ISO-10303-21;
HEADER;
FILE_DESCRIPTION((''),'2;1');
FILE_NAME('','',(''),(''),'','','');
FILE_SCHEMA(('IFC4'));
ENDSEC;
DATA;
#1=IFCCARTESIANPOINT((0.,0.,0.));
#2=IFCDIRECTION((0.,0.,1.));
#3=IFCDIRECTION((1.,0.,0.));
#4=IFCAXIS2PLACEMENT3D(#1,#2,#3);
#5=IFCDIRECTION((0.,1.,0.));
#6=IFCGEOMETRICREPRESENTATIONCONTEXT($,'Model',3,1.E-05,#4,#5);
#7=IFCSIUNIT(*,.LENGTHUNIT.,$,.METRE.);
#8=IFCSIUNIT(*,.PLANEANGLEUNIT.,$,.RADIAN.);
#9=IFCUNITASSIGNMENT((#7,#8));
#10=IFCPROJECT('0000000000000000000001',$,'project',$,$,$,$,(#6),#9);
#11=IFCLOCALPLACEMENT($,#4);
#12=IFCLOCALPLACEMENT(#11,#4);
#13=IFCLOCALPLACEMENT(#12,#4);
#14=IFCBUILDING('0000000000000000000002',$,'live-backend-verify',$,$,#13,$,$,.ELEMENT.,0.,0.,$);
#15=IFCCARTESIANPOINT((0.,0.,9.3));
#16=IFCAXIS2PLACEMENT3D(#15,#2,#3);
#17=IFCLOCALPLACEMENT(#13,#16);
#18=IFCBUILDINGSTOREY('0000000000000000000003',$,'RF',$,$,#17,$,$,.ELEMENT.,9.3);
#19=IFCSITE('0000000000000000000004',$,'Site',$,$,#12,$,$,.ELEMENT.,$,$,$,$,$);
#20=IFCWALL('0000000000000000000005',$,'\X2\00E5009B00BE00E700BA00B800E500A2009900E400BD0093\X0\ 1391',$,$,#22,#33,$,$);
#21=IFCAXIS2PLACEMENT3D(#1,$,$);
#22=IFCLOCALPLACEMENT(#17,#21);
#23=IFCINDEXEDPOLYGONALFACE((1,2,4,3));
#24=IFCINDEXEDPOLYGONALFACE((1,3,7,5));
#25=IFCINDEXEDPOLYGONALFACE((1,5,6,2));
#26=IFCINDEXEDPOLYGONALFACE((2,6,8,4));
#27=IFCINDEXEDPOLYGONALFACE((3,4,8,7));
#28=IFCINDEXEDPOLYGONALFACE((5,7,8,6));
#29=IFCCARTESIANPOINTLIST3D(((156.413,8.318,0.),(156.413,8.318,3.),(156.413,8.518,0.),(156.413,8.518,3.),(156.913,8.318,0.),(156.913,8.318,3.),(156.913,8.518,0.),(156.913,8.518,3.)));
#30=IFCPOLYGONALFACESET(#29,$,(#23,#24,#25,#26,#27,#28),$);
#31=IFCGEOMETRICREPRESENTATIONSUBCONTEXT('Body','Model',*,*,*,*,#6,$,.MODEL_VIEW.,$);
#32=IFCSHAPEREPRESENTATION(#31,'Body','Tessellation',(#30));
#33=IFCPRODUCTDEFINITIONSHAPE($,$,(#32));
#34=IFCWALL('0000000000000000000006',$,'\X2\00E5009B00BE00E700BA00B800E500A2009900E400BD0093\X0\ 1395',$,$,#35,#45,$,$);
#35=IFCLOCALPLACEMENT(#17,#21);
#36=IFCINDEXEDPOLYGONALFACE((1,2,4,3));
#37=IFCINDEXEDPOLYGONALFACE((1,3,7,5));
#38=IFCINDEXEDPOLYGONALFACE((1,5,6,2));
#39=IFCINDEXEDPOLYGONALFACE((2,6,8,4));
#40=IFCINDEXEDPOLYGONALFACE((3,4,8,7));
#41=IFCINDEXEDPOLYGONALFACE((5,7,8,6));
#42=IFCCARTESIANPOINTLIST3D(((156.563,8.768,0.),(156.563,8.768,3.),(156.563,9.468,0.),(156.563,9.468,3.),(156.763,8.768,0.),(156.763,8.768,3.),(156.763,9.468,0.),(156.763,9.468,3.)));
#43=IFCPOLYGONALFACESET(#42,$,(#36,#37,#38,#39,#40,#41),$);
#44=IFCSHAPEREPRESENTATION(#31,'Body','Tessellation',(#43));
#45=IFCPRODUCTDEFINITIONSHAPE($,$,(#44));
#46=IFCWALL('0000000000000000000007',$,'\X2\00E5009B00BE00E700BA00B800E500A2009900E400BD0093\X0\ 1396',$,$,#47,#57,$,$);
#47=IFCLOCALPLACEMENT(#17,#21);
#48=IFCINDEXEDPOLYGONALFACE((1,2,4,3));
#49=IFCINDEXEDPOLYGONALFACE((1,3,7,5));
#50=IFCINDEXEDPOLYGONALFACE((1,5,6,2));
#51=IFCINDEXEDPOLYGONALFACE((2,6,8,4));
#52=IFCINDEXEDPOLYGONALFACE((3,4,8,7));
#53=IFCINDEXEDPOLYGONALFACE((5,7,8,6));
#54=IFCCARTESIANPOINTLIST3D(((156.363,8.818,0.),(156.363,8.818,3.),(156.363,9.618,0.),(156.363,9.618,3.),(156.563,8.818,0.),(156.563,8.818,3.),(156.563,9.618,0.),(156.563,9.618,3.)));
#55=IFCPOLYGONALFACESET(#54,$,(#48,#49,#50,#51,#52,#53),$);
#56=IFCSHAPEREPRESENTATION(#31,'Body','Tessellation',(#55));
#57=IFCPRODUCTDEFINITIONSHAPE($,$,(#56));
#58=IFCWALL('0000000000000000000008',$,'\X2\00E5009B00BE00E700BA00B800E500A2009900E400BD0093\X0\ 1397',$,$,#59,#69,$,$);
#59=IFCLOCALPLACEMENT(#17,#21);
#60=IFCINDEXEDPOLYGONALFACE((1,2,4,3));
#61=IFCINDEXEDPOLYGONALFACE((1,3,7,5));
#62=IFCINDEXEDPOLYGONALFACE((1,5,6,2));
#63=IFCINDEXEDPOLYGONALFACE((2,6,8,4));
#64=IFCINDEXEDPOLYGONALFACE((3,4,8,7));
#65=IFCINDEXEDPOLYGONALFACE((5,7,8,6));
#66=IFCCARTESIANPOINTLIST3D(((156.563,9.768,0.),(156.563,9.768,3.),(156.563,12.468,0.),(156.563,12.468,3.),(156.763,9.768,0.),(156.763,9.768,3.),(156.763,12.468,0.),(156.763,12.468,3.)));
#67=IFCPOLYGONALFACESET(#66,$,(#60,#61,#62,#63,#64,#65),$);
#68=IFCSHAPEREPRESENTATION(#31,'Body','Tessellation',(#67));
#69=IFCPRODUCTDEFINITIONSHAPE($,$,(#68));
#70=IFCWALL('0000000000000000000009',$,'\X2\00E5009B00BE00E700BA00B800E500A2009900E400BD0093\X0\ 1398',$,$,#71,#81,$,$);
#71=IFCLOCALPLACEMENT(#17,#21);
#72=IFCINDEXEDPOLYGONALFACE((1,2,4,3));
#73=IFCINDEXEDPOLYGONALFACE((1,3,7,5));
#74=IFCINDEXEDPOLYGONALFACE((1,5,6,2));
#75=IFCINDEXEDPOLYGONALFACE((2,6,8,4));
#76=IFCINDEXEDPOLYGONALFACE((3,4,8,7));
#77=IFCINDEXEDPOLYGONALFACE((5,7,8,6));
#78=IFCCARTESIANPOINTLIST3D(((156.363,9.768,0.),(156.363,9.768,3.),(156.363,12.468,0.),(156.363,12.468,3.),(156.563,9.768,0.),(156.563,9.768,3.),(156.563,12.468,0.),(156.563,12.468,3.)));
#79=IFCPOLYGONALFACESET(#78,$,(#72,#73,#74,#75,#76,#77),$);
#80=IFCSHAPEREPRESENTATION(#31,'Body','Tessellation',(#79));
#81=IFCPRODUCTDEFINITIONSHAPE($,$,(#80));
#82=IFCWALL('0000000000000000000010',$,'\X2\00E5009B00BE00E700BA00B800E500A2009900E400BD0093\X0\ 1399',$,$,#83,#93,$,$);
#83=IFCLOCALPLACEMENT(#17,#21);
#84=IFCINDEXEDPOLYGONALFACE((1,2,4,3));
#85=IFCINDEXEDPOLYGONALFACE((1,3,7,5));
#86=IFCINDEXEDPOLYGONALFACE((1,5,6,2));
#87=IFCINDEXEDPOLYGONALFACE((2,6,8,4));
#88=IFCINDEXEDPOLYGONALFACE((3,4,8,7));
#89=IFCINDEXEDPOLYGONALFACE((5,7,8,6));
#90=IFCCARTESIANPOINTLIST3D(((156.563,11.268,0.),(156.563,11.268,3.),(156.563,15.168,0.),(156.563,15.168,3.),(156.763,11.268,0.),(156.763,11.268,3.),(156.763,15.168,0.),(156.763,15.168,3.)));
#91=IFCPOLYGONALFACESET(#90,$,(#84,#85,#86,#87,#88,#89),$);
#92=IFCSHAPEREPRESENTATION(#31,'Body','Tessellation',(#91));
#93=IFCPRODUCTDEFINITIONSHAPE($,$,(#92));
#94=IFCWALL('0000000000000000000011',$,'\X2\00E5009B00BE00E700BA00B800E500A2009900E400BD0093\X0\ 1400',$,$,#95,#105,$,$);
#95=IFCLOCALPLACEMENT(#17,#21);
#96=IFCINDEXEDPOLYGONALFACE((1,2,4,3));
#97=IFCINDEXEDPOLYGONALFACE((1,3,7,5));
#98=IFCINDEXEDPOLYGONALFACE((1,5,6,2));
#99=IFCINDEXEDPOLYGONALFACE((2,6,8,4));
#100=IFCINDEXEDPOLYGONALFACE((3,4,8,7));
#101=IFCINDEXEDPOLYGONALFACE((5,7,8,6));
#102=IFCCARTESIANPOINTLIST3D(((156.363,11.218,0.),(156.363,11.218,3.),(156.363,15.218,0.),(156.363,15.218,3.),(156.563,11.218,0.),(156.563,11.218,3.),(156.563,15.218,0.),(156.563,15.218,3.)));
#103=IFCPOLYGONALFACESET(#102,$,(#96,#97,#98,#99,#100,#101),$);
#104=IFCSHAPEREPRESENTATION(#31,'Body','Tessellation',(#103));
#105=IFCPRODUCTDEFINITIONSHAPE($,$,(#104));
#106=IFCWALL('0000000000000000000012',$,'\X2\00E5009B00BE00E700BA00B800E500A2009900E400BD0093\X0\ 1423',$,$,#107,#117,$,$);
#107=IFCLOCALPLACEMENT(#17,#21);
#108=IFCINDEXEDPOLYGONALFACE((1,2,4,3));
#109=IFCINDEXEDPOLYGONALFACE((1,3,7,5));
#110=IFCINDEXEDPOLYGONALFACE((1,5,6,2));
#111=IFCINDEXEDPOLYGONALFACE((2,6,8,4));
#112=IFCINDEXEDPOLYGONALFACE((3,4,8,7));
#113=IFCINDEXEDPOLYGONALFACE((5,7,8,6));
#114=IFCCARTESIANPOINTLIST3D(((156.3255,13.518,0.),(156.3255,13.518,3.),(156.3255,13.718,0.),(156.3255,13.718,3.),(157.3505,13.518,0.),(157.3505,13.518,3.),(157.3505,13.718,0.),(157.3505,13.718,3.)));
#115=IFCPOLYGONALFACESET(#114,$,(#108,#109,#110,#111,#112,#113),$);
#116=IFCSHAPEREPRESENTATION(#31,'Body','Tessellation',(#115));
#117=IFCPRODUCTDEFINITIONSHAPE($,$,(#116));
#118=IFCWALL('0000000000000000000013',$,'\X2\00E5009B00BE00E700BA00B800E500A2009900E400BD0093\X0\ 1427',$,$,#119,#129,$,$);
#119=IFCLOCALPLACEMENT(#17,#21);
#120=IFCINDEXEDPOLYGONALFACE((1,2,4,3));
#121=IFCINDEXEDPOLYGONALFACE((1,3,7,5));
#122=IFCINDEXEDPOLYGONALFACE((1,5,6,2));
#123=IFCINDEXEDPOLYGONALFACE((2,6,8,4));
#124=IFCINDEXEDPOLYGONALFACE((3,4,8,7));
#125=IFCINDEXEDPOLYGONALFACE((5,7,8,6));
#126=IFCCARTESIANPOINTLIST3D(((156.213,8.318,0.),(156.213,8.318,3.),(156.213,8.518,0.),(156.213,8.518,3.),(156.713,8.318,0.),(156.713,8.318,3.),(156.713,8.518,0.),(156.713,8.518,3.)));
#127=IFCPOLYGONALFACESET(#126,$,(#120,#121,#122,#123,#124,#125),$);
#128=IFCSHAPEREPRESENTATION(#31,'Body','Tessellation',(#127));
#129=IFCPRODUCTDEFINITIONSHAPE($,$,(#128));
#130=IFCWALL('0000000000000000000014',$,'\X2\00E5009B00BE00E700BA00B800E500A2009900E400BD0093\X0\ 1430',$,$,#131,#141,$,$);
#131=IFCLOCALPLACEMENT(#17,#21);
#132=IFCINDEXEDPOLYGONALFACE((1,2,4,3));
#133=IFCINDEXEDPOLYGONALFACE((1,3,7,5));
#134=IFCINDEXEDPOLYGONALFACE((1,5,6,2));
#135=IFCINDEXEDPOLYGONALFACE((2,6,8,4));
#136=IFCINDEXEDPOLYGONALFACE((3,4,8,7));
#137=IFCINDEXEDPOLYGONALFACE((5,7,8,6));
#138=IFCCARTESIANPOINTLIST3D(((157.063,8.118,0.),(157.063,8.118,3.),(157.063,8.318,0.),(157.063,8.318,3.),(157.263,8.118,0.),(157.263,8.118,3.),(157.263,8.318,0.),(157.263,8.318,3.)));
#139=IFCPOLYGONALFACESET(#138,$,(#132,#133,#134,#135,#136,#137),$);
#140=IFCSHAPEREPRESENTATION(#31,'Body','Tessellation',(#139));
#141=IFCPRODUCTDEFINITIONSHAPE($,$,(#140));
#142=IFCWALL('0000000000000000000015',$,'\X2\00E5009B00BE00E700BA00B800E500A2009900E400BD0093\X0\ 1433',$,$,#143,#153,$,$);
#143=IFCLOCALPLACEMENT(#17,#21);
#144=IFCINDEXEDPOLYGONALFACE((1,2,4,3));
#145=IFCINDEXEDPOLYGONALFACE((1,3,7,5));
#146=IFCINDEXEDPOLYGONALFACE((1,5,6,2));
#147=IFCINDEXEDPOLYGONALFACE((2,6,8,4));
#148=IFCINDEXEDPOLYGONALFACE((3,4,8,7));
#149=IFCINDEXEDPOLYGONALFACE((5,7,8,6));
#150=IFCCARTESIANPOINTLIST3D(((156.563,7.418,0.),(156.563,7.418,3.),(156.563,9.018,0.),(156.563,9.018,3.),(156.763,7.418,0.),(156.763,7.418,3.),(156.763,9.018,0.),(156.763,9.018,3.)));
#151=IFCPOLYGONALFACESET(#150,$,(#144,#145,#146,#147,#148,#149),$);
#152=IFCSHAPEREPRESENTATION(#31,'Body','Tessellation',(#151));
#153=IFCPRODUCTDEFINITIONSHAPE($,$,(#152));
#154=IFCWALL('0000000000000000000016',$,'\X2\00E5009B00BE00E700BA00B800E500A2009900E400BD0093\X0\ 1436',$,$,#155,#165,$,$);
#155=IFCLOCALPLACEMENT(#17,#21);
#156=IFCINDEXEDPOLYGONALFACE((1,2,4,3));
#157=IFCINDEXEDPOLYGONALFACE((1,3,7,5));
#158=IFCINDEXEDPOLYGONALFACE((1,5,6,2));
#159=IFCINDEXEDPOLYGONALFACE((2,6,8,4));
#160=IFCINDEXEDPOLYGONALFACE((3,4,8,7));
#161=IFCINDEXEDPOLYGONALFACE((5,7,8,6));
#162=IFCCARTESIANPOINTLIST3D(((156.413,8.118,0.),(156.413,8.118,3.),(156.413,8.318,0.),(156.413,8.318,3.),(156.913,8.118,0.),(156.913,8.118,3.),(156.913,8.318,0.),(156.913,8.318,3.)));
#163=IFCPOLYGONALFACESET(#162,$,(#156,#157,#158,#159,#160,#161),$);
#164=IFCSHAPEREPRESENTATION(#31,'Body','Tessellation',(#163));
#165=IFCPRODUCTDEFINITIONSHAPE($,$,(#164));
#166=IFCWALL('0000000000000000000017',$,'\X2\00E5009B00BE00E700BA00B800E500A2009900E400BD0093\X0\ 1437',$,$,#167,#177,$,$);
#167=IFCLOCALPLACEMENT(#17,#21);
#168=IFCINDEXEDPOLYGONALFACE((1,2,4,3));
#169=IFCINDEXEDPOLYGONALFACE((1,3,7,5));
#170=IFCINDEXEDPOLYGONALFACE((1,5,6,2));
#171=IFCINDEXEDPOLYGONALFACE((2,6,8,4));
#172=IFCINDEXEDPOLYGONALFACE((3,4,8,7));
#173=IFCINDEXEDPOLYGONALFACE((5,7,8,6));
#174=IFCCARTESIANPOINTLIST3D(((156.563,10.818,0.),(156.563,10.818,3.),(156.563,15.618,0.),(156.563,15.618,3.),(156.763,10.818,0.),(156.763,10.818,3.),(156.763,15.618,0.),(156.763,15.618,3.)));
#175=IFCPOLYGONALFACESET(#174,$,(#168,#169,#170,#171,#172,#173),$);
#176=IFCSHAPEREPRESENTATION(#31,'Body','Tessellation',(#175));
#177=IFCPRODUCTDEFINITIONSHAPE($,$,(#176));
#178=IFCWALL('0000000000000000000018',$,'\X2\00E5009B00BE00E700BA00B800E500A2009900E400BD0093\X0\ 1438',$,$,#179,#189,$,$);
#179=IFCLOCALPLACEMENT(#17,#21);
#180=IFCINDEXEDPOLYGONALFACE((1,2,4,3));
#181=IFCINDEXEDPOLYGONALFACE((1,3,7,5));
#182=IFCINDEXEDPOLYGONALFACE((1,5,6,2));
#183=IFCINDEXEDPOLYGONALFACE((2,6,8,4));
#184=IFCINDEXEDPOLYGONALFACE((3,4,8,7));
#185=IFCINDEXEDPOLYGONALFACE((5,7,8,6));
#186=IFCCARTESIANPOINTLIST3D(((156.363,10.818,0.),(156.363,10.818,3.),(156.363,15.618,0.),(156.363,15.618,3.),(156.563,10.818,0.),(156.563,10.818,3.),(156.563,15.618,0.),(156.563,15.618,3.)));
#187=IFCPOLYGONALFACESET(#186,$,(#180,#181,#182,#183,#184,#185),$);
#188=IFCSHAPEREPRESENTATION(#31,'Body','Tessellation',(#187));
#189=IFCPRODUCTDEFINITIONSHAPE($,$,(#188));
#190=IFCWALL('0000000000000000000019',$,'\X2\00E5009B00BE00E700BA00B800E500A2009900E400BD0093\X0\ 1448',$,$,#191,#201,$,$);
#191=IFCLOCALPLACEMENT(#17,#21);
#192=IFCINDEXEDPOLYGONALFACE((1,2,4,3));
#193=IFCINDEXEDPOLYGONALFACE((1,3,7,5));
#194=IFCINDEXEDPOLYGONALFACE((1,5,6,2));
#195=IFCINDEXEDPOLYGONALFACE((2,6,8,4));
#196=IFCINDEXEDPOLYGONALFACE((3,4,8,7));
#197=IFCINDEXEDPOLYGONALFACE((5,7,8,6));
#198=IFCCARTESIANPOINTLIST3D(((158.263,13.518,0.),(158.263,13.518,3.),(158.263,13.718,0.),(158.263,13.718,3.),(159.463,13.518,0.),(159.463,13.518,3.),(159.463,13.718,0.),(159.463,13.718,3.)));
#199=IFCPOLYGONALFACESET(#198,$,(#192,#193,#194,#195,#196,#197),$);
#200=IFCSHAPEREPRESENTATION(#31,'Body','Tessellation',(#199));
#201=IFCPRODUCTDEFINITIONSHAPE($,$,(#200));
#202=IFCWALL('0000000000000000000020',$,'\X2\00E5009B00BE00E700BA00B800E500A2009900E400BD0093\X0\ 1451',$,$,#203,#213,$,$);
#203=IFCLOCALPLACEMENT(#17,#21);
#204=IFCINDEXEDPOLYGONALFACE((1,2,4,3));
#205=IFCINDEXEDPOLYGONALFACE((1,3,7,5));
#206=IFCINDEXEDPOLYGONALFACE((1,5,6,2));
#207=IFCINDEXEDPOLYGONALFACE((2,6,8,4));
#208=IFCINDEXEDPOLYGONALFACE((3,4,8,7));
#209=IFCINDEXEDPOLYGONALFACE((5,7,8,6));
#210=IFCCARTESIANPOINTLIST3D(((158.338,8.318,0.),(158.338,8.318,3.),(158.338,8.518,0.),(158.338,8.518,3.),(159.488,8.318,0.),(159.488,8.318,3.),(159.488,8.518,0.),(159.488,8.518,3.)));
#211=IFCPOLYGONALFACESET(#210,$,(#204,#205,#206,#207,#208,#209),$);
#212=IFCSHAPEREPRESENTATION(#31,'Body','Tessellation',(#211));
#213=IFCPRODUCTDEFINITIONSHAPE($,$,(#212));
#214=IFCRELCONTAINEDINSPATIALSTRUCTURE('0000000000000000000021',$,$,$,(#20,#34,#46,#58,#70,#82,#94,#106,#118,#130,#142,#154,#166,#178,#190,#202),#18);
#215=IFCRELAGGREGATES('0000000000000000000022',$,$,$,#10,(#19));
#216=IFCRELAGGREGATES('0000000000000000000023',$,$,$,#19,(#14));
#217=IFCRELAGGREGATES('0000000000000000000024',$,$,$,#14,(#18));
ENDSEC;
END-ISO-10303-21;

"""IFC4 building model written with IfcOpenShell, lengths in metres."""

from ifc_helpers import new_model, si_unit, direction, frame, frame_2d, origin_with_axes, place, context, subcontext, project, spatial, rectangle, extrude, element, save


model = new_model("IFC4")

# Units and contexts
model_context = context("Model", 3, precision=1e-05, world=origin_with_axes(), true_north=direction((0.0, 1.0, 0.0)))
body_context = subcontext(model_context, "Body", "Model", "MODEL_VIEW")
ifc_project = project(units=[si_unit("LENGTHUNIT", "METRE"), si_unit("PLANEANGLEUNIT", "RADIAN")], contexts=[model_context])

# Site, building, storey
placement = place(None, origin_with_axes())
site_placement = place(placement, origin_with_axes())
site = spatial("IfcSite", under=ifc_project, at=site_placement, Name="Site", CompositionType="ELEMENT")
building_placement = place(site_placement, origin_with_axes())
building = spatial("IfcBuilding", under=site, at=building_placement, Name="live-backend-verify", CompositionType="ELEMENT", ElevationOfRefHeight=0.0, ElevationOfTerrain=0.0)
storey_placement = place(building_placement, frame((0.0, 0.0, 9.3), z_axis=(0.0, 0.0, 1.0), x_axis=(1.0, 0.0, 0.0)))
storey = spatial("IfcBuildingStorey", under=building, at=storey_placement, Name="RF", CompositionType="ELEMENT", Elevation=9.3)

# Walls
wall_1_placement = place(storey_placement, frame((156.663, 8.418, 0.0), z_axis=(0.0, 0.0, 1.0), x_axis=(1.0, 0.0, 0.0)))
element("IfcWall", 1, at=wall_1_placement, inside=storey, Name="å\u009b¾çº¸å¢\u0099ä½\u0093 1391", context=body_context, shape_type="SweptSolid", body=[
    extrude(rectangle(XDim=0.5, YDim=0.2, at=frame_2d((0.0, 0.0), x_axis=(1.0, 0.0, 0.0))), frame((0.0, 0.0, 0.0), z_axis=(0.0, 0.0, 1.0)), (0.0, 0.0, 1.0), 3.0),
])
wall_2_placement = place(storey_placement, frame((156.663, 9.118, 0.0), z_axis=(0.0, 0.0, 1.0), x_axis=(0.0, -1.0, 0.0)))
element("IfcWall", 2, at=wall_2_placement, inside=storey, Name="å\u009b¾çº¸å¢\u0099ä½\u0093 1395", context=body_context, shape_type="SweptSolid", body=[
    extrude(rectangle(XDim=0.7, YDim=0.2, at=frame_2d((0.0, 0.0), x_axis=(1.0, 0.0, 0.0))), frame((0.0, 0.0, 0.0), z_axis=(0.0, 0.0, 1.0)), (0.0, 0.0, 1.0), 3.0),
])
wall_3_placement = place(storey_placement, frame((156.463, 9.218, 0.0), z_axis=(0.0, 0.0, 1.0), x_axis=(0.0, -1.0, 0.0)))
element("IfcWall", 3, at=wall_3_placement, inside=storey, Name="å\u009b¾çº¸å¢\u0099ä½\u0093 1396", context=body_context, shape_type="SweptSolid", body=[
    extrude(rectangle(XDim=0.8, YDim=0.2, at=frame_2d((0.0, 0.0), x_axis=(1.0, 0.0, 0.0))), frame((0.0, 0.0, 0.0), z_axis=(0.0, 0.0, 1.0)), (0.0, 0.0, 1.0), 3.0),
])
for number, where, z_axis, x_axis, name in (
    (4, (156.663, 11.118, 0.0), (0.0, 0.0, 1.0), (0.0, -1.0, 0.0), "å\u009b¾çº¸å¢\u0099ä½\u0093 1397"),
    (5, (156.463, 11.118, 0.0), (0.0, 0.0, 1.0), (0.0, -1.0, 0.0), "å\u009b¾çº¸å¢\u0099ä½\u0093 1398"),
):
    element("IfcWall", number, at=place(storey_placement, frame(where, z_axis=z_axis, x_axis=x_axis)), inside=storey, Name=name, context=body_context, shape_type="SweptSolid", body=[
        extrude(rectangle(XDim=2.7, YDim=0.2, at=frame_2d((0.0, 0.0), x_axis=(1.0, 0.0, 0.0))), frame((0.0, 0.0, 0.0), z_axis=(0.0, 0.0, 1.0)), (0.0, 0.0, 1.0), 3.0),
    ])
wall_4_placement = place(storey_placement, frame((156.663, 13.218, 0.0), z_axis=(0.0, 0.0, 1.0), x_axis=(0.0, -1.0, 0.0)))
element("IfcWall", 6, at=wall_4_placement, inside=storey, Name="å\u009b¾çº¸å¢\u0099ä½\u0093 1399", context=body_context, shape_type="SweptSolid", body=[
    extrude(rectangle(XDim=3.9, YDim=0.2, at=frame_2d((0.0, 0.0), x_axis=(1.0, 0.0, 0.0))), frame((0.0, 0.0, 0.0), z_axis=(0.0, 0.0, 1.0)), (0.0, 0.0, 1.0), 3.0),
])
wall_5_placement = place(storey_placement, frame((156.463, 13.218, 0.0), z_axis=(0.0, 0.0, 1.0), x_axis=(0.0, -1.0, 0.0)))
element("IfcWall", 7, at=wall_5_placement, inside=storey, Name="å\u009b¾çº¸å¢\u0099ä½\u0093 1400", context=body_context, shape_type="SweptSolid", body=[
    extrude(rectangle(XDim=4.0, YDim=0.2, at=frame_2d((0.0, 0.0), x_axis=(1.0, 0.0, 0.0))), frame((0.0, 0.0, 0.0), z_axis=(0.0, 0.0, 1.0)), (0.0, 0.0, 1.0), 3.0),
])
wall_6_placement = place(storey_placement, frame((156.838, 13.618, 0.0), z_axis=(0.0, 0.0, 1.0), x_axis=(1.0, 0.0, 0.0)))
element("IfcWall", 8, at=wall_6_placement, inside=storey, Name="å\u009b¾çº¸å¢\u0099ä½\u0093 1423", context=body_context, shape_type="SweptSolid", body=[
    extrude(rectangle(XDim=1.025, YDim=0.2, at=frame_2d((0.0, 0.0), x_axis=(1.0, 0.0, 0.0))), frame((0.0, 0.0, 0.0), z_axis=(0.0, 0.0, 1.0)), (0.0, 0.0, 1.0), 3.0),
])
wall_7_placement = place(storey_placement, frame((156.463, 8.418, 0.0), z_axis=(0.0, 0.0, 1.0), x_axis=(-1.0, 0.0, 0.0)))
element("IfcWall", 9, at=wall_7_placement, inside=storey, Name="å\u009b¾çº¸å¢\u0099ä½\u0093 1427", context=body_context, shape_type="SweptSolid", body=[
    extrude(rectangle(XDim=0.5, YDim=0.2, at=frame_2d((0.0, 0.0), x_axis=(1.0, 0.0, 0.0))), frame((0.0, 0.0, 0.0), z_axis=(0.0, 0.0, 1.0)), (0.0, 0.0, 1.0), 3.0),
])
wall_8_placement = place(storey_placement, frame((157.163, 8.218, 0.0), z_axis=(0.0, 0.0, 1.0), x_axis=(0.0, 1.0, 0.0)))
element("IfcWall", 10, at=wall_8_placement, inside=storey, Name="å\u009b¾çº¸å¢\u0099ä½\u0093 1430", context=body_context, shape_type="SweptSolid", body=[
    extrude(rectangle(XDim=0.2, YDim=0.2, at=frame_2d((0.0, 0.0), x_axis=(1.0, 0.0, 0.0))), frame((0.0, 0.0, 0.0), z_axis=(0.0, 0.0, 1.0)), (0.0, 0.0, 1.0), 3.0),
])
wall_9_placement = place(storey_placement, frame((156.663, 8.218, 0.0), z_axis=(0.0, 0.0, 1.0), x_axis=(0.0, -1.0, 0.0)))
element("IfcWall", 11, at=wall_9_placement, inside=storey, Name="å\u009b¾çº¸å¢\u0099ä½\u0093 1433", context=body_context, shape_type="SweptSolid", body=[
    extrude(rectangle(XDim=1.6, YDim=0.2, at=frame_2d((0.0, 0.0), x_axis=(1.0, 0.0, 0.0))), frame((0.0, 0.0, 0.0), z_axis=(0.0, 0.0, 1.0)), (0.0, 0.0, 1.0), 3.0),
])
for number, where, z_axis, x_axis, name in (
    (12, (156.663, 8.218, 0.0), (0.0, 0.0, 1.0), (1.0, 0.0, 0.0), "å\u009b¾çº¸å¢\u0099ä½\u0093 1436"),
):
    element("IfcWall", number, at=place(storey_placement, frame(where, z_axis=z_axis, x_axis=x_axis)), inside=storey, Name=name, context=body_context, shape_type="SweptSolid", body=[
        extrude(rectangle(XDim=0.5, YDim=0.2, at=frame_2d((0.0, 0.0), x_axis=(1.0, 0.0, 0.0))), frame((0.0, 0.0, 0.0), z_axis=(0.0, 0.0, 1.0)), (0.0, 0.0, 1.0), 3.0),
    ])
for number, where, z_axis, x_axis, name in (
    (13, (156.663, 13.218, 0.0), (0.0, 0.0, 1.0), (0.0, -1.0, 0.0), "å\u009b¾çº¸å¢\u0099ä½\u0093 1437"),
    (14, (156.463, 13.218, 0.0), (0.0, 0.0, 1.0), (0.0, -1.0, 0.0), "å\u009b¾çº¸å¢\u0099ä½\u0093 1438"),
):
    element("IfcWall", number, at=place(storey_placement, frame(where, z_axis=z_axis, x_axis=x_axis)), inside=storey, Name=name, context=body_context, shape_type="SweptSolid", body=[
        extrude(rectangle(XDim=4.8, YDim=0.2, at=frame_2d((0.0, 0.0), x_axis=(1.0, 0.0, 0.0))), frame((0.0, 0.0, 0.0), z_axis=(0.0, 0.0, 1.0)), (0.0, 0.0, 1.0), 3.0),
    ])
wall_10_placement = place(storey_placement, frame((158.863, 13.618, 0.0), z_axis=(0.0, 0.0, 1.0), x_axis=(1.0, 0.0, 0.0)))
element("IfcWall", 15, at=wall_10_placement, inside=storey, Name="å\u009b¾çº¸å¢\u0099ä½\u0093 1448", context=body_context, shape_type="SweptSolid", body=[
    extrude(rectangle(XDim=1.2, YDim=0.2, at=frame_2d((0.0, 0.0), x_axis=(1.0, 0.0, 0.0))), frame((0.0, 0.0, 0.0), z_axis=(0.0, 0.0, 1.0)), (0.0, 0.0, 1.0), 3.0),
])
wall_11_placement = place(storey_placement, frame((158.913, 8.418, 0.0), z_axis=(0.0, 0.0, 1.0), x_axis=(1.0, 0.0, 0.0)))
element("IfcWall", 16, at=wall_11_placement, inside=storey, Name="å\u009b¾çº¸å¢\u0099ä½\u0093 1451", context=body_context, shape_type="SweptSolid", body=[
    extrude(rectangle(XDim=1.15, YDim=0.2, at=frame_2d((0.0, 0.0), x_axis=(1.0, 0.0, 0.0))), frame((0.0, 0.0, 0.0), z_axis=(0.0, 0.0, 1.0)), (0.0, 0.0, 1.0), 3.0),
])

save(model, "model.ifc")
